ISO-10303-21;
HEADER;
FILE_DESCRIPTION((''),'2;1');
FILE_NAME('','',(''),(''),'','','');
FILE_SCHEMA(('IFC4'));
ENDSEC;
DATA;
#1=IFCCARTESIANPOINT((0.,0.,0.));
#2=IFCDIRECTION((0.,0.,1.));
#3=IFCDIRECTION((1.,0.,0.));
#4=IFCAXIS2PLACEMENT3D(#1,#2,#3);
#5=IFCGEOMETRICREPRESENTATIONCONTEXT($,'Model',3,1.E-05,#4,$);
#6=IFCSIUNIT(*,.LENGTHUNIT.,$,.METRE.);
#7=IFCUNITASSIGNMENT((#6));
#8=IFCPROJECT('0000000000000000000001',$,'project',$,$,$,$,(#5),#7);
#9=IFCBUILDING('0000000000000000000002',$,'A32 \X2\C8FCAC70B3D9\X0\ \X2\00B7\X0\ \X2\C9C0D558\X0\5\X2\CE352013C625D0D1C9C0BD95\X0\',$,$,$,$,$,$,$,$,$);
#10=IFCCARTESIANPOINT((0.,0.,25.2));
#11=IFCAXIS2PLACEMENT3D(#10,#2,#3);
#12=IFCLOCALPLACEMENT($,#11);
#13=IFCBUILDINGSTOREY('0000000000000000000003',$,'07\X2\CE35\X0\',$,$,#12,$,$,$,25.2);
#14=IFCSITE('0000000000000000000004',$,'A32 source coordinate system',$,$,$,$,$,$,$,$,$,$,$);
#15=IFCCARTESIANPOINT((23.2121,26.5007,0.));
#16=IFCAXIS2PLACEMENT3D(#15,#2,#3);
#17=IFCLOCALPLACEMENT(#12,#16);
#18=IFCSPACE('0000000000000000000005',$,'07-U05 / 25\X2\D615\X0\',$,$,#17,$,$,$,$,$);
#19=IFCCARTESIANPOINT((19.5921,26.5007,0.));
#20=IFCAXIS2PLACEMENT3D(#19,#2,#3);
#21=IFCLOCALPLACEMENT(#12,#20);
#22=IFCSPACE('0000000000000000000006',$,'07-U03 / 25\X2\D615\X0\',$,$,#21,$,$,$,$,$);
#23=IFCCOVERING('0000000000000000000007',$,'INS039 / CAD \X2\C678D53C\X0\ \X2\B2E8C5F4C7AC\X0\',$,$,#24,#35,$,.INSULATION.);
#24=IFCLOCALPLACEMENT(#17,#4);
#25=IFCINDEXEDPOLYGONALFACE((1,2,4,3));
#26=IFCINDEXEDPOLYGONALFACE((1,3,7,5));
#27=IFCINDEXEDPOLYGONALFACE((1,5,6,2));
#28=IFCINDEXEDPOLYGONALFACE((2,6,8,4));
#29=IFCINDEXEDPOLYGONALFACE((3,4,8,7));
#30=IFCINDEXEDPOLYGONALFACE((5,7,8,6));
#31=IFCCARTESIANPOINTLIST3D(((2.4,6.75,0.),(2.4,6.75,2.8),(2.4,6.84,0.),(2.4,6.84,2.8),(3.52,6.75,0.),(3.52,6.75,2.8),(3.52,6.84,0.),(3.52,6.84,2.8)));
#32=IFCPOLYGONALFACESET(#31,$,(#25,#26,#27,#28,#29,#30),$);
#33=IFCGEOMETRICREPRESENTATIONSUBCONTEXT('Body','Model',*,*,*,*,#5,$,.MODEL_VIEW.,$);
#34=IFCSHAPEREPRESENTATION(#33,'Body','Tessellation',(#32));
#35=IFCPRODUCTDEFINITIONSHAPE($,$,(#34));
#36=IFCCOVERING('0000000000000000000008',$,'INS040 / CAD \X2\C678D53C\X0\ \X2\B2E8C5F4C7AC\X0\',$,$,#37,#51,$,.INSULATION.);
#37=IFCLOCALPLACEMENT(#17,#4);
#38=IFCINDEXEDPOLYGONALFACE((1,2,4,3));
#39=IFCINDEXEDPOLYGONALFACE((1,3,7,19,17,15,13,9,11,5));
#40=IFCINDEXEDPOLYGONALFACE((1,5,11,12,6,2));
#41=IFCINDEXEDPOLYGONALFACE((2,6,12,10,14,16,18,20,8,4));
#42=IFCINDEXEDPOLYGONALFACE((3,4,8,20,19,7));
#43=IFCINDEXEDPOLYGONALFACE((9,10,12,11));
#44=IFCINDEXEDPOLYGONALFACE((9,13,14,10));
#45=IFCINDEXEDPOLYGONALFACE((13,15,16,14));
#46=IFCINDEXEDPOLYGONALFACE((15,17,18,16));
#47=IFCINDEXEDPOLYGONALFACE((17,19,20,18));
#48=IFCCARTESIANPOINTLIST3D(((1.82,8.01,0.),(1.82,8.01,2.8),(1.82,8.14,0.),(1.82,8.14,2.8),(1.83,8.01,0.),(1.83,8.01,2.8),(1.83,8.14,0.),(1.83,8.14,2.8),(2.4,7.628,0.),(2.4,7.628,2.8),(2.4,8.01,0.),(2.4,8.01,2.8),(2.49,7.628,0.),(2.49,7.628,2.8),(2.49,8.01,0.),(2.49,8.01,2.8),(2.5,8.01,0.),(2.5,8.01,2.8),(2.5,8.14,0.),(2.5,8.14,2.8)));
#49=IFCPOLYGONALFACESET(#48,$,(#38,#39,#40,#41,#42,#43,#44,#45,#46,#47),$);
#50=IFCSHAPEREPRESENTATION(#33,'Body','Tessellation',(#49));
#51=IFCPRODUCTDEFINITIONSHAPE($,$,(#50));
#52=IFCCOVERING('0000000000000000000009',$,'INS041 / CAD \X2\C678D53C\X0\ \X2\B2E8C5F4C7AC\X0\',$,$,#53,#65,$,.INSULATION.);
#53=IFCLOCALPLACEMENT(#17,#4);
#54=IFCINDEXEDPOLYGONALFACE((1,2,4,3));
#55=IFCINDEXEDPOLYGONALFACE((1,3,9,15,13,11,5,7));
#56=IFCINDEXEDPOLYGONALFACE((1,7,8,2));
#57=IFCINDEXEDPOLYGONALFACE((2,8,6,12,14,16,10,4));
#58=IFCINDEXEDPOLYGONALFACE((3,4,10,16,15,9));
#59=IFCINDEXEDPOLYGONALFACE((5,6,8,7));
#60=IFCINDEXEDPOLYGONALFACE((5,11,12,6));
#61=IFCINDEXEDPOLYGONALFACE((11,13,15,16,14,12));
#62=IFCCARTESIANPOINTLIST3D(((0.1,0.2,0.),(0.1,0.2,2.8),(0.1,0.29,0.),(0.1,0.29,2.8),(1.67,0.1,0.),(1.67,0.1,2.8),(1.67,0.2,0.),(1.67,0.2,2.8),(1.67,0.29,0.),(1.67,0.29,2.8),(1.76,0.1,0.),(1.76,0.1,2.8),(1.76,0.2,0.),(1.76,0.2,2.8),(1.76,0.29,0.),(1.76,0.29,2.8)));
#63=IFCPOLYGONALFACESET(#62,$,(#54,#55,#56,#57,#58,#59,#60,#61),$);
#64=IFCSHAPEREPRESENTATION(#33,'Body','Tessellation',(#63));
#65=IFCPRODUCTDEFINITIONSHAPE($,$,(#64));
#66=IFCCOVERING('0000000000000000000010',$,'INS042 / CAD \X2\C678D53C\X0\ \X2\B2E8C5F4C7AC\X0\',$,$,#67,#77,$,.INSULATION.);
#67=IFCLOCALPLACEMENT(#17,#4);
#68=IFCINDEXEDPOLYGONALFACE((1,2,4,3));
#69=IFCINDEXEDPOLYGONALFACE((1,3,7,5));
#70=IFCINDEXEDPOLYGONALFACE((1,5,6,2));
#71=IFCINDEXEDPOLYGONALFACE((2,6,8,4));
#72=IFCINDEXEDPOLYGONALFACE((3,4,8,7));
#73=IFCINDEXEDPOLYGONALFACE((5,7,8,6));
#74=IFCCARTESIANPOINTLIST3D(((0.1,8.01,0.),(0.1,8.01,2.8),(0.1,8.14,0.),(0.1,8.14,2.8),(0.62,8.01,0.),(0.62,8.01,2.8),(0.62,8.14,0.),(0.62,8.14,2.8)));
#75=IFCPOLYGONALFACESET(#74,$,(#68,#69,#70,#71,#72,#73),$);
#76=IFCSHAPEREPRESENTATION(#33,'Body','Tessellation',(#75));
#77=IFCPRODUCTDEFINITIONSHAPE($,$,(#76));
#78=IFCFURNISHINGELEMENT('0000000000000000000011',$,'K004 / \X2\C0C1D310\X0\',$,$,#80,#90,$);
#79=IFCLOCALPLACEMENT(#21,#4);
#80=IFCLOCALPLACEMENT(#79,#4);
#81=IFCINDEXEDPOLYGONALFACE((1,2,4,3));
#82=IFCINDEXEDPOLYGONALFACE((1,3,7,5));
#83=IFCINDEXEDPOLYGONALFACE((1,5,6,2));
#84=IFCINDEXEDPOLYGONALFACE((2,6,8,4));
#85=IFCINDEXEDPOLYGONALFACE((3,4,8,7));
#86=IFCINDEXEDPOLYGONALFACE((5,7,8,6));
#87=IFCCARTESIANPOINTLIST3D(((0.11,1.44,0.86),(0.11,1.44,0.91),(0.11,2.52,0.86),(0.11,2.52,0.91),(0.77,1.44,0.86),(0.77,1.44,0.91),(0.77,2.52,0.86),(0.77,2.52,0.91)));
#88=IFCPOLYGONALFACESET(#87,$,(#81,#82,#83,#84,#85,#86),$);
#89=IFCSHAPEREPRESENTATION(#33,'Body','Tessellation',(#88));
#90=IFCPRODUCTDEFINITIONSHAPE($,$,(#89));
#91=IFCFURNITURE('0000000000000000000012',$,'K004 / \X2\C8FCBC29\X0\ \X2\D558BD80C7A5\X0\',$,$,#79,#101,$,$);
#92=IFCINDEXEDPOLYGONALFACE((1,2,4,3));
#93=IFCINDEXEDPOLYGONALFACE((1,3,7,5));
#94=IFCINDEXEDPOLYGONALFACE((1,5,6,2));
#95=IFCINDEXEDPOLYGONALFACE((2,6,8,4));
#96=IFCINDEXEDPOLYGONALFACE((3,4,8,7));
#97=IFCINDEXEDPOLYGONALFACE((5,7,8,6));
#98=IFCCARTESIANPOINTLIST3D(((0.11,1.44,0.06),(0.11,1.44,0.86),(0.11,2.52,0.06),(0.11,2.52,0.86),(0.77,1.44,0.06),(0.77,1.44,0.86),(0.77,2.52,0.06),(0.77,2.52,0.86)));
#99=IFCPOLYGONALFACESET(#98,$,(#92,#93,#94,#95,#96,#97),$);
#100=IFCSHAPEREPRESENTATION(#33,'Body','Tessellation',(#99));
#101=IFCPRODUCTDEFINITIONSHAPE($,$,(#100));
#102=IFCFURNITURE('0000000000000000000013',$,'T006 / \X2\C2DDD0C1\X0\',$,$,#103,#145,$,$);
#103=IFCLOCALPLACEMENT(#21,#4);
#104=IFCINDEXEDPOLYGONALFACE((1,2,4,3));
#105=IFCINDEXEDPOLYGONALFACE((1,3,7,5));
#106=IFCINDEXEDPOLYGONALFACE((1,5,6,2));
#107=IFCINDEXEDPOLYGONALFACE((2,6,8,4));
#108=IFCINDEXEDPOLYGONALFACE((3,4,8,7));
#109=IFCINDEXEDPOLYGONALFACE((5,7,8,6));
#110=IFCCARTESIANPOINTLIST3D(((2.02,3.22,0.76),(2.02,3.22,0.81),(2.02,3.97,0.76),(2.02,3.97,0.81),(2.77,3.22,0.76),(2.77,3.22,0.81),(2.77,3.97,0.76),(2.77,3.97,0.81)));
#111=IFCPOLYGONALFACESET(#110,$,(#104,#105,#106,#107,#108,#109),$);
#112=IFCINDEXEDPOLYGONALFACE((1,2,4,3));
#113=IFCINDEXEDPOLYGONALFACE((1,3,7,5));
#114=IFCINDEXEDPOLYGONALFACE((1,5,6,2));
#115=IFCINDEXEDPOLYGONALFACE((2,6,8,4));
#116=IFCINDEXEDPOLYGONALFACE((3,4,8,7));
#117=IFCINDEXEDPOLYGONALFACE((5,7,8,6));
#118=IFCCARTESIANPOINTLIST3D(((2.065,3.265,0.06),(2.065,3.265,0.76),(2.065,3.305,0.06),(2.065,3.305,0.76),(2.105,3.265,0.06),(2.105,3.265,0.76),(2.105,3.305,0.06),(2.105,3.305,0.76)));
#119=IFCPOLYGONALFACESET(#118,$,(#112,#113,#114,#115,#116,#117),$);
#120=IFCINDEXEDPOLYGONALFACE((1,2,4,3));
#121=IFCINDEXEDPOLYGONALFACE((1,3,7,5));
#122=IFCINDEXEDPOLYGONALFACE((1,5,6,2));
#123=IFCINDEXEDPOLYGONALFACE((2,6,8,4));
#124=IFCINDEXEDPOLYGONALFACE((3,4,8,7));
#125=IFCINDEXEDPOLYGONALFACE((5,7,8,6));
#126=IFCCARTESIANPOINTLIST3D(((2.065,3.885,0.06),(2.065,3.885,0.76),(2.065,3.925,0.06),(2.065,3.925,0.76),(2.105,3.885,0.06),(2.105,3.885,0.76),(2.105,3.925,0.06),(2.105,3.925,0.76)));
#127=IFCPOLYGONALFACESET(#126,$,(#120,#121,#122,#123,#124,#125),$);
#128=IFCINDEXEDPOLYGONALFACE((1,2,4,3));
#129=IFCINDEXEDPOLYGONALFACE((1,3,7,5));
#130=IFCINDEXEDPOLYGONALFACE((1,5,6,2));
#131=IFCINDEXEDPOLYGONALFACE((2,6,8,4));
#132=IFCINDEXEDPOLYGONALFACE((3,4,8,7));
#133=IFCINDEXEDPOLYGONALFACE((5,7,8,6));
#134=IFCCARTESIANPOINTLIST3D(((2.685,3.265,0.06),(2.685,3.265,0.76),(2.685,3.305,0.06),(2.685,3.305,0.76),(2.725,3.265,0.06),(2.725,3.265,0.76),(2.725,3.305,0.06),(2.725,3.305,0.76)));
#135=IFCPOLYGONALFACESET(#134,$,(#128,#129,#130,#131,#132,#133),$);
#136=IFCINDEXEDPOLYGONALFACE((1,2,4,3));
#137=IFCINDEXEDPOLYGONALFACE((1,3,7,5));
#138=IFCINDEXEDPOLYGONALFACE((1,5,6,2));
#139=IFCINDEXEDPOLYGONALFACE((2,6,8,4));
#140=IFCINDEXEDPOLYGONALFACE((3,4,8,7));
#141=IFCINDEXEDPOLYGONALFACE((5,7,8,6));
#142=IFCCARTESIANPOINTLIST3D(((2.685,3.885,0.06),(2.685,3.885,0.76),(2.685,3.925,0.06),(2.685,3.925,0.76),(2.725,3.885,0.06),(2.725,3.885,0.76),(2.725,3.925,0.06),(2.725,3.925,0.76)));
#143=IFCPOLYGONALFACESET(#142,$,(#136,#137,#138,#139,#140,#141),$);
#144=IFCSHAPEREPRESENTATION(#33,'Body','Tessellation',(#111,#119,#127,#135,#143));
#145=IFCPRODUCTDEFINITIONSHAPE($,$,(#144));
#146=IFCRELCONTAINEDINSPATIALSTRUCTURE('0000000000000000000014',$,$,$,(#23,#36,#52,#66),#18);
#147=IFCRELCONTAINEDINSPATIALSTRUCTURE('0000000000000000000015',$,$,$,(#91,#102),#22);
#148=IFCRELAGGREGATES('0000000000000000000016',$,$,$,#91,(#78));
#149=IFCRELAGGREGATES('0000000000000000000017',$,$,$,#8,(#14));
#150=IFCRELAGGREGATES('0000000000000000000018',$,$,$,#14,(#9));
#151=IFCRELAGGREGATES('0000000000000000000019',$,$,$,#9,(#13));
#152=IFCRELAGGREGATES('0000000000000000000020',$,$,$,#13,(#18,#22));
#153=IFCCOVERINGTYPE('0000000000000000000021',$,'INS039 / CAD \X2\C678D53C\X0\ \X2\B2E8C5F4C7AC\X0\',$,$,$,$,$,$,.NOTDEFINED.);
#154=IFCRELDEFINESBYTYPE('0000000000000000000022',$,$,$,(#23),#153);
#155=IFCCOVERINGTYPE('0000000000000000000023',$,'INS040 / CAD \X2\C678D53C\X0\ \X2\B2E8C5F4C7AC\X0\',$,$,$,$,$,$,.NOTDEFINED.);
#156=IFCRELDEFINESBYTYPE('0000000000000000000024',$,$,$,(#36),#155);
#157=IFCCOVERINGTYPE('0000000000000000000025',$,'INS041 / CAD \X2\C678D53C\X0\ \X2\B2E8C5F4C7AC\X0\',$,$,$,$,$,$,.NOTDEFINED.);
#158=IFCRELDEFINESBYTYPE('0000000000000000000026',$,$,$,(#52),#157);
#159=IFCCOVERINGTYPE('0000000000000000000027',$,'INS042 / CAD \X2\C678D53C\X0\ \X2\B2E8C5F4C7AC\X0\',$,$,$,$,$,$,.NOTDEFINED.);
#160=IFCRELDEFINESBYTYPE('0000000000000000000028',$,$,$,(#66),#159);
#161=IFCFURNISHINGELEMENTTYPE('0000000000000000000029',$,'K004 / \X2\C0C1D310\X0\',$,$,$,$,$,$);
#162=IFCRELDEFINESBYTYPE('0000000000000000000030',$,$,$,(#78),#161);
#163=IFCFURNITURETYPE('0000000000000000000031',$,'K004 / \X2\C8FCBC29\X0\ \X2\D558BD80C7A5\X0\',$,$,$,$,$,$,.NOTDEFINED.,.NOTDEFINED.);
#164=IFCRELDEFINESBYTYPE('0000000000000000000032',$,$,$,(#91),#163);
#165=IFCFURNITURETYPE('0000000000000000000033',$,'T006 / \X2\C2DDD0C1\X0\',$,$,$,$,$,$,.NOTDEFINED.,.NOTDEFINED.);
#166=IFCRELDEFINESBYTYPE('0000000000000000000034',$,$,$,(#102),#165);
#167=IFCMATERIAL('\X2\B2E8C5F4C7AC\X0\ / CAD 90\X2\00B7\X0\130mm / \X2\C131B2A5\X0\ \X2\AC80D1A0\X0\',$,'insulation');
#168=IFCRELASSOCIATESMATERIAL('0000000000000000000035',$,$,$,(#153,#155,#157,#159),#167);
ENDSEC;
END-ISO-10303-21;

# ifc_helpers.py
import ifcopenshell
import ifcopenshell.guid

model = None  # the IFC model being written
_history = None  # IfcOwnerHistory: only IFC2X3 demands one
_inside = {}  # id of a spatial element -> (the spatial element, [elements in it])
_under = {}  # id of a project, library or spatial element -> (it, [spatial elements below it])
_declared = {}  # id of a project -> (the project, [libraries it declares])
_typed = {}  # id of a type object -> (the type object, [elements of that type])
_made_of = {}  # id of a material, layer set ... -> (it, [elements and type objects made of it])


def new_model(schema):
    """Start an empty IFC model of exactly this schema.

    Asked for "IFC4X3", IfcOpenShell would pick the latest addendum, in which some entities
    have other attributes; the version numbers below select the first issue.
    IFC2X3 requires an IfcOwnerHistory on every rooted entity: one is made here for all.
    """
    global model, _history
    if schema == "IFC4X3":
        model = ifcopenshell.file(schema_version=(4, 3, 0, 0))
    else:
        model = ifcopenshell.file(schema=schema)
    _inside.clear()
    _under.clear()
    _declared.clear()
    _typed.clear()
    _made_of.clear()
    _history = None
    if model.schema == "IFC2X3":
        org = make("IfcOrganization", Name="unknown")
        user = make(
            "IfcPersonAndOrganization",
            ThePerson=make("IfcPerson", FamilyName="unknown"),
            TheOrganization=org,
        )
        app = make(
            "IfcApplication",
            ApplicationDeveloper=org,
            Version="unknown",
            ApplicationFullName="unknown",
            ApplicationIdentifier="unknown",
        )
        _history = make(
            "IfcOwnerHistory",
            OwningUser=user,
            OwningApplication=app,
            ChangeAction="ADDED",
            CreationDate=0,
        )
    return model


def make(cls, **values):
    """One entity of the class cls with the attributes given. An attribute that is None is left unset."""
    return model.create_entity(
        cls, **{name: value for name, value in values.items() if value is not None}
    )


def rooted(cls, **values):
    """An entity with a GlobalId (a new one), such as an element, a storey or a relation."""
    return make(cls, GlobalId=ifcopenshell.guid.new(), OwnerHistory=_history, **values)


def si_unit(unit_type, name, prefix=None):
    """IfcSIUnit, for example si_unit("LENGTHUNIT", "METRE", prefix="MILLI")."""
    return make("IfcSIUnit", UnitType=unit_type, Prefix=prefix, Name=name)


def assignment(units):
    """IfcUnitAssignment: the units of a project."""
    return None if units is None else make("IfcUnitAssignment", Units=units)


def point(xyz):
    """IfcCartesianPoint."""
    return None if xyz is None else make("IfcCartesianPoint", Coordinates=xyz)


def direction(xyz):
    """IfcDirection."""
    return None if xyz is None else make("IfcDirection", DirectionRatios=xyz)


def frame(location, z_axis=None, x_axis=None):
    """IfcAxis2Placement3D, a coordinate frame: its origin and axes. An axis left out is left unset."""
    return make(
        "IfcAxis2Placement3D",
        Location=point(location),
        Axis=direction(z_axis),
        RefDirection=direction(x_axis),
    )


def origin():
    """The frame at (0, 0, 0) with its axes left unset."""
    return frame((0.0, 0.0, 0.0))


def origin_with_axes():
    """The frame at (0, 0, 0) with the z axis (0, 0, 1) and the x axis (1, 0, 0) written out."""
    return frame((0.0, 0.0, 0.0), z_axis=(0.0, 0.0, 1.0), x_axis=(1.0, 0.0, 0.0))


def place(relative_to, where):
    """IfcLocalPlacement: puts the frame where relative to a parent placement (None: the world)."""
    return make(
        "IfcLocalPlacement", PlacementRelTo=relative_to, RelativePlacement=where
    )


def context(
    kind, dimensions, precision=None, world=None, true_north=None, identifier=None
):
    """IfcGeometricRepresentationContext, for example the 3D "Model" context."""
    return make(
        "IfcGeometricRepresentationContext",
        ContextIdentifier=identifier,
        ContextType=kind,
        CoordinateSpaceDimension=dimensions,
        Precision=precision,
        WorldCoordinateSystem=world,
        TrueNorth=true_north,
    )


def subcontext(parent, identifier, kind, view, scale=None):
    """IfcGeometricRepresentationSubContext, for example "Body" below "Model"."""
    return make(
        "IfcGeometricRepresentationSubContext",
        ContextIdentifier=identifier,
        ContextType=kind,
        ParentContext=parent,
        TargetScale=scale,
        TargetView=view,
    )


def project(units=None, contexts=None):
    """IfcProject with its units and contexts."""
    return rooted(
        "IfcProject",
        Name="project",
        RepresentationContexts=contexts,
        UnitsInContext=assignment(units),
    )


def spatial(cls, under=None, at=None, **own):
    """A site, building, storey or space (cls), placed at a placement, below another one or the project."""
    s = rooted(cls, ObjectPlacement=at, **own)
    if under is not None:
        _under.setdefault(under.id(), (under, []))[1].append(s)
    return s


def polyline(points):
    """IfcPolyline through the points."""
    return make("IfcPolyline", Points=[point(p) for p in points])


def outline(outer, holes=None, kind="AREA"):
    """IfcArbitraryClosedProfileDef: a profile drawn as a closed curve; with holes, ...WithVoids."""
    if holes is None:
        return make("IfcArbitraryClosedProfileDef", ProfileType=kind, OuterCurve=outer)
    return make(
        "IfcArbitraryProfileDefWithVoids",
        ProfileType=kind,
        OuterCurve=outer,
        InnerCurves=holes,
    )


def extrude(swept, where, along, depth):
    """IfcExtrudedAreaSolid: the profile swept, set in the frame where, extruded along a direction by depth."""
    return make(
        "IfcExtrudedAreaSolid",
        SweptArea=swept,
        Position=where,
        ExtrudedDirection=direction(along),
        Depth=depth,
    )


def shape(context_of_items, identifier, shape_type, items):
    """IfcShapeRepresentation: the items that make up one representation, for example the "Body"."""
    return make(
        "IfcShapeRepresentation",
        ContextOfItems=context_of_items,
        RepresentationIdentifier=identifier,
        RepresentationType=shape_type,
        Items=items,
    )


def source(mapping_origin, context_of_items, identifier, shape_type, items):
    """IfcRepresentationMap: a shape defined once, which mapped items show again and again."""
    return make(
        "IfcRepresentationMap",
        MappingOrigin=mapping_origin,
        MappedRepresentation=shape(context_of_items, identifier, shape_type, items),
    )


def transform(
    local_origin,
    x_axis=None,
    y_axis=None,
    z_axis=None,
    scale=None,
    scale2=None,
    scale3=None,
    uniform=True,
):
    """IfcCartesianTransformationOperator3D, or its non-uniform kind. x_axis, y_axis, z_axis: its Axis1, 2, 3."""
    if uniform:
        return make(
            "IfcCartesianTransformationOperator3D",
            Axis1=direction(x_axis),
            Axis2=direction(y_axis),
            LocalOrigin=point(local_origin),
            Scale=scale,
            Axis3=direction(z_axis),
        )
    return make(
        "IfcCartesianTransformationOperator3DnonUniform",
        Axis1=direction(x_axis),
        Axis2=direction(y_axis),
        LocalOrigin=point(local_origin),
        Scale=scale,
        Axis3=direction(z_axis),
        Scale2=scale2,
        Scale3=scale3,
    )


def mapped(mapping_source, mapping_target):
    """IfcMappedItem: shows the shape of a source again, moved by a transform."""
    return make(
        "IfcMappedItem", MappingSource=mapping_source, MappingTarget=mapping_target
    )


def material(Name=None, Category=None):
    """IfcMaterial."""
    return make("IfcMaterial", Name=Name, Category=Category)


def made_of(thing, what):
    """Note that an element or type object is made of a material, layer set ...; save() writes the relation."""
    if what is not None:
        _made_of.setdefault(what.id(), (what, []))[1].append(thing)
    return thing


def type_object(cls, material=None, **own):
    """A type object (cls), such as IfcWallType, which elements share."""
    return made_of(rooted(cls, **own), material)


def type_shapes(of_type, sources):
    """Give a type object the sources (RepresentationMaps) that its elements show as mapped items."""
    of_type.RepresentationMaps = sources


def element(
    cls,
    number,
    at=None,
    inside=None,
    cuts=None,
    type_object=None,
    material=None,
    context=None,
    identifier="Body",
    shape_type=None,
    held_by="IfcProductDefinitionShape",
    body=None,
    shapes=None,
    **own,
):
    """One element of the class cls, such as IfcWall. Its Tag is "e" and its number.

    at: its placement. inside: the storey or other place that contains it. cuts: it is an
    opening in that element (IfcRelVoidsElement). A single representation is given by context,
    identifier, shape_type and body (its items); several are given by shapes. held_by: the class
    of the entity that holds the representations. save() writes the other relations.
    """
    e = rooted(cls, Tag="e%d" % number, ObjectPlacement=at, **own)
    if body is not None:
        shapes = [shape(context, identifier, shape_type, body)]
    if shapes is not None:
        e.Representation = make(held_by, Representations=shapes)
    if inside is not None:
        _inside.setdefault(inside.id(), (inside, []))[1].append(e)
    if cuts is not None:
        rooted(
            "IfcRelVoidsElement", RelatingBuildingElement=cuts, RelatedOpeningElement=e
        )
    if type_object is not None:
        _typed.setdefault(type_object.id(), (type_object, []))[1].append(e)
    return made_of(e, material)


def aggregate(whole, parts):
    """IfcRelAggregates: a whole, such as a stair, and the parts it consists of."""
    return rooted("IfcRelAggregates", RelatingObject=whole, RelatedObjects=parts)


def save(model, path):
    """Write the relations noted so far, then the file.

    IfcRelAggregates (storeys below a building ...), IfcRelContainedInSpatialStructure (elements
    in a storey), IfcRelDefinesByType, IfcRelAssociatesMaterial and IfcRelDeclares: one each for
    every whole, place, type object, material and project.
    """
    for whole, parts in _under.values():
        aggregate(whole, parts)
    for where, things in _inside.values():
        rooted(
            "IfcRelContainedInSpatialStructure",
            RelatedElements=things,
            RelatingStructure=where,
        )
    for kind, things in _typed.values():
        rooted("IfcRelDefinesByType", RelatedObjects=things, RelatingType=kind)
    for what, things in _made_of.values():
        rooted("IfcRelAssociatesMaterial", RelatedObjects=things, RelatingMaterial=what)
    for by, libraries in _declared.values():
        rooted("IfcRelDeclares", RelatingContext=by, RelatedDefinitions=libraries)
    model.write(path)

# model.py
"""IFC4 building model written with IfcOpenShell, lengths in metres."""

from ifc_helpers import new_model, si_unit, frame, origin, origin_with_axes, place, context, subcontext, project, spatial, polyline, outline, extrude, source, transform, mapped, material, type_object, type_shapes, element, aggregate, save


model = new_model("IFC4")

# Units and contexts
model_context = context("Model", 3, precision=1e-05, world=origin_with_axes())
body_context = subcontext(model_context, "Body", "Model", "MODEL_VIEW")
ifc_project = project(units=[si_unit("LENGTHUNIT", "METRE")], contexts=[model_context])

# Site, building, storey, space
storey_placement = place(None, frame((0.0, 0.0, 25.2), z_axis=(0.0, 0.0, 1.0), x_axis=(1.0, 0.0, 0.0)))
space_1_placement = place(storey_placement, frame((23.2121, 26.5007, 0.0), z_axis=(0.0, 0.0, 1.0), x_axis=(1.0, 0.0, 0.0)))
site = spatial("IfcSite", under=ifc_project, Name="A32 source coordinate system")
building = spatial("IfcBuilding", under=site, Name="A32 주거동 · 지하5층–옥탑지붕")
storey = spatial("IfcBuildingStorey", under=building, at=storey_placement, Name="07층", Elevation=25.2)
space_1 = spatial("IfcSpace", under=storey, at=space_1_placement, Name="07-U05 / 25형")

# Shared definitions
space_2_placement = place(storey_placement, frame((19.5921, 26.5007, 0.0), z_axis=(0.0, 0.0, 1.0), x_axis=(1.0, 0.0, 0.0)))
space_2 = spatial("IfcSpace", under=storey, at=space_2_placement, Name="07-U03 / 25형")

# Coverings
ifc_material = material(Name="단열재 / CAD 90·130mm / 성능 검토", Category="insulation")
covering_type_1 = type_object("IfcCoveringType", Name="INS039 / CAD 외피 단열재", PredefinedType="NOTDEFINED", material=ifc_material)
shared_shape_1 = source(origin(), body_context, "Body", "SweptSolid", [
    extrude(outline(polyline([(2.4, 6.75), (2.4, 6.84), (3.52, 6.84), (3.52, 6.75), (2.4, 6.75)])), origin(), (0.0, 0.0, 1.0), 2.8),
])
type_shapes(covering_type_1, [shared_shape_1])
covering_1_placement = place(space_1_placement, origin_with_axes())
element("IfcCovering", 1, at=covering_1_placement, inside=space_1, type_object=covering_type_1, Name="INS039 / CAD 외피 단열재", PredefinedType="INSULATION", context=body_context, shape_type="MappedRepresentation", body=[
    mapped(shared_shape_1, transform((0.0, 0.0, 0.0), scale=1.0)),
])
covering_type_2 = type_object("IfcCoveringType", Name="INS040 / CAD 외피 단열재", PredefinedType="NOTDEFINED", material=ifc_material)
shared_shape_2 = source(origin(), body_context, "Body", "SweptSolid", [
    extrude(outline(polyline([(2.4, 7.628), (2.4, 8.01), (1.83, 8.01), (1.82, 8.01), (1.82, 8.14), (1.83, 8.14), (2.5, 8.14), (2.5, 8.01), (2.49, 8.01), (2.49, 7.628), (2.4, 7.628)])), origin(), (0.0, 0.0, 1.0), 2.8),
])
type_shapes(covering_type_2, [shared_shape_2])
covering_2_placement = place(space_1_placement, origin_with_axes())
element("IfcCovering", 2, at=covering_2_placement, inside=space_1, type_object=covering_type_2, Name="INS040 / CAD 외피 단열재", PredefinedType="INSULATION", context=body_context, shape_type="MappedRepresentation", body=[
    mapped(shared_shape_2, transform((0.0, 0.0, 0.0), scale=1.0)),
])
covering_type_3 = type_object("IfcCoveringType", Name="INS041 / CAD 외피 단열재", PredefinedType="NOTDEFINED", material=ifc_material)
shared_shape_3 = source(origin(), body_context, "Body", "SweptSolid", [
    extrude(outline(polyline([(1.67, 0.2), (0.1, 0.2), (0.1, 0.29), (1.67, 0.29), (1.76, 0.29), (1.76, 0.2), (1.76, 0.1), (1.67, 0.1), (1.67, 0.2)])), origin(), (0.0, 0.0, 1.0), 2.8),
])
type_shapes(covering_type_3, [shared_shape_3])
covering_3_placement = place(space_1_placement, origin_with_axes())
element("IfcCovering", 3, at=covering_3_placement, inside=space_1, type_object=covering_type_3, Name="INS041 / CAD 외피 단열재", PredefinedType="INSULATION", context=body_context, shape_type="MappedRepresentation", body=[
    mapped(shared_shape_3, transform((0.0, 0.0, 0.0), scale=1.0)),
])
covering_type_4 = type_object("IfcCoveringType", Name="INS042 / CAD 외피 단열재", PredefinedType="NOTDEFINED", material=ifc_material)
shared_shape_4 = source(origin(), body_context, "Body", "SweptSolid", [
    extrude(outline(polyline([(0.62, 8.14), (0.62, 8.01), (0.1, 8.01), (0.1, 8.14), (0.62, 8.14)])), origin(), (0.0, 0.0, 1.0), 2.8),
])
type_shapes(covering_type_4, [shared_shape_4])
covering_4_placement = place(space_1_placement, origin_with_axes())
element("IfcCovering", 4, at=covering_4_placement, inside=space_1, type_object=covering_type_4, Name="INS042 / CAD 외피 단열재", PredefinedType="INSULATION", context=body_context, shape_type="MappedRepresentation", body=[
    mapped(shared_shape_4, transform((0.0, 0.0, 0.0), scale=1.0)),
])

# Furnishing element
furnishing_element_type_1 = type_object("IfcFurnishingElementType", Name="K004 / 상판")
shared_shape_5 = source(origin(), body_context, "Body", "SweptSolid", [
    extrude(outline(polyline([(0.77, 2.52), (0.77, 1.44), (0.11, 1.44), (0.11, 2.52), (0.77, 2.52)])), frame((0.0, 0.0, 0.86)), (0.0, 0.0, 1.0), 0.05),
])
type_shapes(furnishing_element_type_1, [shared_shape_5])
furniture_1_placement = place(space_2_placement, origin_with_axes())
furnishing_1_placement = place(furniture_1_placement, origin_with_axes())
furnishing_1 = element("IfcFurnishingElement", 5, at=furnishing_1_placement, type_object=furnishing_element_type_1, Name="K004 / 상판", context=body_context, shape_type="MappedRepresentation", body=[
    mapped(shared_shape_5, transform((0.0, 0.0, 0.0), scale=1.0)),
])

# Furniture
furniture_type_1 = type_object("IfcFurnitureType", Name="K004 / 주방 하부장", AssemblyPlace="NOTDEFINED", PredefinedType="NOTDEFINED")
shared_shape_6 = source(origin(), body_context, "Body", "SweptSolid", [
    extrude(outline(polyline([(0.11, 2.52), (0.77, 2.52), (0.77, 1.44), (0.11, 1.44), (0.11, 2.52)])), frame((0.0, 0.0, 0.06)), (0.0, 0.0, 1.0), 0.8),
])
type_shapes(furniture_type_1, [shared_shape_6])
furniture_1 = element("IfcFurniture", 6, at=furniture_1_placement, inside=space_2, type_object=furniture_type_1, Name="K004 / 주방 하부장", context=body_context, shape_type="MappedRepresentation", body=[
    mapped(shared_shape_6, transform((0.0, 0.0, 0.0), scale=1.0)),
])
aggregate(furniture_1, [furnishing_1])
furniture_type_2 = type_object("IfcFurnitureType", Name="T006 / 식탁", AssemblyPlace="NOTDEFINED", PredefinedType="NOTDEFINED")
shared_shape_7 = source(origin(), body_context, "Body", "SweptSolid", [
    extrude(outline(polyline([(2.77, 3.22), (2.02, 3.22), (2.02, 3.97), (2.77, 3.97), (2.77, 3.22)])), frame((0.0, 0.0, 0.76)), (0.0, 0.0, 1.0), 0.05),
    extrude(outline(polyline([(2.065, 3.265), (2.065, 3.305), (2.105, 3.305), (2.105, 3.265), (2.065, 3.265)])), frame((0.0, 0.0, 0.06)), (0.0, 0.0, 1.0), 0.7),
    extrude(outline(polyline([(2.065, 3.885), (2.065, 3.925), (2.105, 3.925), (2.105, 3.885), (2.065, 3.885)])), frame((0.0, 0.0, 0.06)), (0.0, 0.0, 1.0), 0.7),
    extrude(outline(polyline([(2.685, 3.265), (2.685, 3.305), (2.725, 3.305), (2.725, 3.265), (2.685, 3.265)])), frame((0.0, 0.0, 0.06)), (0.0, 0.0, 1.0), 0.7),
    extrude(outline(polyline([(2.685, 3.885), (2.685, 3.925), (2.725, 3.925), (2.725, 3.885), (2.685, 3.885)])), frame((0.0, 0.0, 0.06)), (0.0, 0.0, 1.0), 0.7),
])
type_shapes(furniture_type_2, [shared_shape_7])
furniture_2_placement = place(space_2_placement, origin_with_axes())
element("IfcFurniture", 7, at=furniture_2_placement, inside=space_2, type_object=furniture_type_2, Name="T006 / 식탁", context=body_context, shape_type="MappedRepresentation", body=[
    mapped(shared_shape_7, transform((0.0, 0.0, 0.0), scale=1.0)),
])

save(model, "model.ifc")
